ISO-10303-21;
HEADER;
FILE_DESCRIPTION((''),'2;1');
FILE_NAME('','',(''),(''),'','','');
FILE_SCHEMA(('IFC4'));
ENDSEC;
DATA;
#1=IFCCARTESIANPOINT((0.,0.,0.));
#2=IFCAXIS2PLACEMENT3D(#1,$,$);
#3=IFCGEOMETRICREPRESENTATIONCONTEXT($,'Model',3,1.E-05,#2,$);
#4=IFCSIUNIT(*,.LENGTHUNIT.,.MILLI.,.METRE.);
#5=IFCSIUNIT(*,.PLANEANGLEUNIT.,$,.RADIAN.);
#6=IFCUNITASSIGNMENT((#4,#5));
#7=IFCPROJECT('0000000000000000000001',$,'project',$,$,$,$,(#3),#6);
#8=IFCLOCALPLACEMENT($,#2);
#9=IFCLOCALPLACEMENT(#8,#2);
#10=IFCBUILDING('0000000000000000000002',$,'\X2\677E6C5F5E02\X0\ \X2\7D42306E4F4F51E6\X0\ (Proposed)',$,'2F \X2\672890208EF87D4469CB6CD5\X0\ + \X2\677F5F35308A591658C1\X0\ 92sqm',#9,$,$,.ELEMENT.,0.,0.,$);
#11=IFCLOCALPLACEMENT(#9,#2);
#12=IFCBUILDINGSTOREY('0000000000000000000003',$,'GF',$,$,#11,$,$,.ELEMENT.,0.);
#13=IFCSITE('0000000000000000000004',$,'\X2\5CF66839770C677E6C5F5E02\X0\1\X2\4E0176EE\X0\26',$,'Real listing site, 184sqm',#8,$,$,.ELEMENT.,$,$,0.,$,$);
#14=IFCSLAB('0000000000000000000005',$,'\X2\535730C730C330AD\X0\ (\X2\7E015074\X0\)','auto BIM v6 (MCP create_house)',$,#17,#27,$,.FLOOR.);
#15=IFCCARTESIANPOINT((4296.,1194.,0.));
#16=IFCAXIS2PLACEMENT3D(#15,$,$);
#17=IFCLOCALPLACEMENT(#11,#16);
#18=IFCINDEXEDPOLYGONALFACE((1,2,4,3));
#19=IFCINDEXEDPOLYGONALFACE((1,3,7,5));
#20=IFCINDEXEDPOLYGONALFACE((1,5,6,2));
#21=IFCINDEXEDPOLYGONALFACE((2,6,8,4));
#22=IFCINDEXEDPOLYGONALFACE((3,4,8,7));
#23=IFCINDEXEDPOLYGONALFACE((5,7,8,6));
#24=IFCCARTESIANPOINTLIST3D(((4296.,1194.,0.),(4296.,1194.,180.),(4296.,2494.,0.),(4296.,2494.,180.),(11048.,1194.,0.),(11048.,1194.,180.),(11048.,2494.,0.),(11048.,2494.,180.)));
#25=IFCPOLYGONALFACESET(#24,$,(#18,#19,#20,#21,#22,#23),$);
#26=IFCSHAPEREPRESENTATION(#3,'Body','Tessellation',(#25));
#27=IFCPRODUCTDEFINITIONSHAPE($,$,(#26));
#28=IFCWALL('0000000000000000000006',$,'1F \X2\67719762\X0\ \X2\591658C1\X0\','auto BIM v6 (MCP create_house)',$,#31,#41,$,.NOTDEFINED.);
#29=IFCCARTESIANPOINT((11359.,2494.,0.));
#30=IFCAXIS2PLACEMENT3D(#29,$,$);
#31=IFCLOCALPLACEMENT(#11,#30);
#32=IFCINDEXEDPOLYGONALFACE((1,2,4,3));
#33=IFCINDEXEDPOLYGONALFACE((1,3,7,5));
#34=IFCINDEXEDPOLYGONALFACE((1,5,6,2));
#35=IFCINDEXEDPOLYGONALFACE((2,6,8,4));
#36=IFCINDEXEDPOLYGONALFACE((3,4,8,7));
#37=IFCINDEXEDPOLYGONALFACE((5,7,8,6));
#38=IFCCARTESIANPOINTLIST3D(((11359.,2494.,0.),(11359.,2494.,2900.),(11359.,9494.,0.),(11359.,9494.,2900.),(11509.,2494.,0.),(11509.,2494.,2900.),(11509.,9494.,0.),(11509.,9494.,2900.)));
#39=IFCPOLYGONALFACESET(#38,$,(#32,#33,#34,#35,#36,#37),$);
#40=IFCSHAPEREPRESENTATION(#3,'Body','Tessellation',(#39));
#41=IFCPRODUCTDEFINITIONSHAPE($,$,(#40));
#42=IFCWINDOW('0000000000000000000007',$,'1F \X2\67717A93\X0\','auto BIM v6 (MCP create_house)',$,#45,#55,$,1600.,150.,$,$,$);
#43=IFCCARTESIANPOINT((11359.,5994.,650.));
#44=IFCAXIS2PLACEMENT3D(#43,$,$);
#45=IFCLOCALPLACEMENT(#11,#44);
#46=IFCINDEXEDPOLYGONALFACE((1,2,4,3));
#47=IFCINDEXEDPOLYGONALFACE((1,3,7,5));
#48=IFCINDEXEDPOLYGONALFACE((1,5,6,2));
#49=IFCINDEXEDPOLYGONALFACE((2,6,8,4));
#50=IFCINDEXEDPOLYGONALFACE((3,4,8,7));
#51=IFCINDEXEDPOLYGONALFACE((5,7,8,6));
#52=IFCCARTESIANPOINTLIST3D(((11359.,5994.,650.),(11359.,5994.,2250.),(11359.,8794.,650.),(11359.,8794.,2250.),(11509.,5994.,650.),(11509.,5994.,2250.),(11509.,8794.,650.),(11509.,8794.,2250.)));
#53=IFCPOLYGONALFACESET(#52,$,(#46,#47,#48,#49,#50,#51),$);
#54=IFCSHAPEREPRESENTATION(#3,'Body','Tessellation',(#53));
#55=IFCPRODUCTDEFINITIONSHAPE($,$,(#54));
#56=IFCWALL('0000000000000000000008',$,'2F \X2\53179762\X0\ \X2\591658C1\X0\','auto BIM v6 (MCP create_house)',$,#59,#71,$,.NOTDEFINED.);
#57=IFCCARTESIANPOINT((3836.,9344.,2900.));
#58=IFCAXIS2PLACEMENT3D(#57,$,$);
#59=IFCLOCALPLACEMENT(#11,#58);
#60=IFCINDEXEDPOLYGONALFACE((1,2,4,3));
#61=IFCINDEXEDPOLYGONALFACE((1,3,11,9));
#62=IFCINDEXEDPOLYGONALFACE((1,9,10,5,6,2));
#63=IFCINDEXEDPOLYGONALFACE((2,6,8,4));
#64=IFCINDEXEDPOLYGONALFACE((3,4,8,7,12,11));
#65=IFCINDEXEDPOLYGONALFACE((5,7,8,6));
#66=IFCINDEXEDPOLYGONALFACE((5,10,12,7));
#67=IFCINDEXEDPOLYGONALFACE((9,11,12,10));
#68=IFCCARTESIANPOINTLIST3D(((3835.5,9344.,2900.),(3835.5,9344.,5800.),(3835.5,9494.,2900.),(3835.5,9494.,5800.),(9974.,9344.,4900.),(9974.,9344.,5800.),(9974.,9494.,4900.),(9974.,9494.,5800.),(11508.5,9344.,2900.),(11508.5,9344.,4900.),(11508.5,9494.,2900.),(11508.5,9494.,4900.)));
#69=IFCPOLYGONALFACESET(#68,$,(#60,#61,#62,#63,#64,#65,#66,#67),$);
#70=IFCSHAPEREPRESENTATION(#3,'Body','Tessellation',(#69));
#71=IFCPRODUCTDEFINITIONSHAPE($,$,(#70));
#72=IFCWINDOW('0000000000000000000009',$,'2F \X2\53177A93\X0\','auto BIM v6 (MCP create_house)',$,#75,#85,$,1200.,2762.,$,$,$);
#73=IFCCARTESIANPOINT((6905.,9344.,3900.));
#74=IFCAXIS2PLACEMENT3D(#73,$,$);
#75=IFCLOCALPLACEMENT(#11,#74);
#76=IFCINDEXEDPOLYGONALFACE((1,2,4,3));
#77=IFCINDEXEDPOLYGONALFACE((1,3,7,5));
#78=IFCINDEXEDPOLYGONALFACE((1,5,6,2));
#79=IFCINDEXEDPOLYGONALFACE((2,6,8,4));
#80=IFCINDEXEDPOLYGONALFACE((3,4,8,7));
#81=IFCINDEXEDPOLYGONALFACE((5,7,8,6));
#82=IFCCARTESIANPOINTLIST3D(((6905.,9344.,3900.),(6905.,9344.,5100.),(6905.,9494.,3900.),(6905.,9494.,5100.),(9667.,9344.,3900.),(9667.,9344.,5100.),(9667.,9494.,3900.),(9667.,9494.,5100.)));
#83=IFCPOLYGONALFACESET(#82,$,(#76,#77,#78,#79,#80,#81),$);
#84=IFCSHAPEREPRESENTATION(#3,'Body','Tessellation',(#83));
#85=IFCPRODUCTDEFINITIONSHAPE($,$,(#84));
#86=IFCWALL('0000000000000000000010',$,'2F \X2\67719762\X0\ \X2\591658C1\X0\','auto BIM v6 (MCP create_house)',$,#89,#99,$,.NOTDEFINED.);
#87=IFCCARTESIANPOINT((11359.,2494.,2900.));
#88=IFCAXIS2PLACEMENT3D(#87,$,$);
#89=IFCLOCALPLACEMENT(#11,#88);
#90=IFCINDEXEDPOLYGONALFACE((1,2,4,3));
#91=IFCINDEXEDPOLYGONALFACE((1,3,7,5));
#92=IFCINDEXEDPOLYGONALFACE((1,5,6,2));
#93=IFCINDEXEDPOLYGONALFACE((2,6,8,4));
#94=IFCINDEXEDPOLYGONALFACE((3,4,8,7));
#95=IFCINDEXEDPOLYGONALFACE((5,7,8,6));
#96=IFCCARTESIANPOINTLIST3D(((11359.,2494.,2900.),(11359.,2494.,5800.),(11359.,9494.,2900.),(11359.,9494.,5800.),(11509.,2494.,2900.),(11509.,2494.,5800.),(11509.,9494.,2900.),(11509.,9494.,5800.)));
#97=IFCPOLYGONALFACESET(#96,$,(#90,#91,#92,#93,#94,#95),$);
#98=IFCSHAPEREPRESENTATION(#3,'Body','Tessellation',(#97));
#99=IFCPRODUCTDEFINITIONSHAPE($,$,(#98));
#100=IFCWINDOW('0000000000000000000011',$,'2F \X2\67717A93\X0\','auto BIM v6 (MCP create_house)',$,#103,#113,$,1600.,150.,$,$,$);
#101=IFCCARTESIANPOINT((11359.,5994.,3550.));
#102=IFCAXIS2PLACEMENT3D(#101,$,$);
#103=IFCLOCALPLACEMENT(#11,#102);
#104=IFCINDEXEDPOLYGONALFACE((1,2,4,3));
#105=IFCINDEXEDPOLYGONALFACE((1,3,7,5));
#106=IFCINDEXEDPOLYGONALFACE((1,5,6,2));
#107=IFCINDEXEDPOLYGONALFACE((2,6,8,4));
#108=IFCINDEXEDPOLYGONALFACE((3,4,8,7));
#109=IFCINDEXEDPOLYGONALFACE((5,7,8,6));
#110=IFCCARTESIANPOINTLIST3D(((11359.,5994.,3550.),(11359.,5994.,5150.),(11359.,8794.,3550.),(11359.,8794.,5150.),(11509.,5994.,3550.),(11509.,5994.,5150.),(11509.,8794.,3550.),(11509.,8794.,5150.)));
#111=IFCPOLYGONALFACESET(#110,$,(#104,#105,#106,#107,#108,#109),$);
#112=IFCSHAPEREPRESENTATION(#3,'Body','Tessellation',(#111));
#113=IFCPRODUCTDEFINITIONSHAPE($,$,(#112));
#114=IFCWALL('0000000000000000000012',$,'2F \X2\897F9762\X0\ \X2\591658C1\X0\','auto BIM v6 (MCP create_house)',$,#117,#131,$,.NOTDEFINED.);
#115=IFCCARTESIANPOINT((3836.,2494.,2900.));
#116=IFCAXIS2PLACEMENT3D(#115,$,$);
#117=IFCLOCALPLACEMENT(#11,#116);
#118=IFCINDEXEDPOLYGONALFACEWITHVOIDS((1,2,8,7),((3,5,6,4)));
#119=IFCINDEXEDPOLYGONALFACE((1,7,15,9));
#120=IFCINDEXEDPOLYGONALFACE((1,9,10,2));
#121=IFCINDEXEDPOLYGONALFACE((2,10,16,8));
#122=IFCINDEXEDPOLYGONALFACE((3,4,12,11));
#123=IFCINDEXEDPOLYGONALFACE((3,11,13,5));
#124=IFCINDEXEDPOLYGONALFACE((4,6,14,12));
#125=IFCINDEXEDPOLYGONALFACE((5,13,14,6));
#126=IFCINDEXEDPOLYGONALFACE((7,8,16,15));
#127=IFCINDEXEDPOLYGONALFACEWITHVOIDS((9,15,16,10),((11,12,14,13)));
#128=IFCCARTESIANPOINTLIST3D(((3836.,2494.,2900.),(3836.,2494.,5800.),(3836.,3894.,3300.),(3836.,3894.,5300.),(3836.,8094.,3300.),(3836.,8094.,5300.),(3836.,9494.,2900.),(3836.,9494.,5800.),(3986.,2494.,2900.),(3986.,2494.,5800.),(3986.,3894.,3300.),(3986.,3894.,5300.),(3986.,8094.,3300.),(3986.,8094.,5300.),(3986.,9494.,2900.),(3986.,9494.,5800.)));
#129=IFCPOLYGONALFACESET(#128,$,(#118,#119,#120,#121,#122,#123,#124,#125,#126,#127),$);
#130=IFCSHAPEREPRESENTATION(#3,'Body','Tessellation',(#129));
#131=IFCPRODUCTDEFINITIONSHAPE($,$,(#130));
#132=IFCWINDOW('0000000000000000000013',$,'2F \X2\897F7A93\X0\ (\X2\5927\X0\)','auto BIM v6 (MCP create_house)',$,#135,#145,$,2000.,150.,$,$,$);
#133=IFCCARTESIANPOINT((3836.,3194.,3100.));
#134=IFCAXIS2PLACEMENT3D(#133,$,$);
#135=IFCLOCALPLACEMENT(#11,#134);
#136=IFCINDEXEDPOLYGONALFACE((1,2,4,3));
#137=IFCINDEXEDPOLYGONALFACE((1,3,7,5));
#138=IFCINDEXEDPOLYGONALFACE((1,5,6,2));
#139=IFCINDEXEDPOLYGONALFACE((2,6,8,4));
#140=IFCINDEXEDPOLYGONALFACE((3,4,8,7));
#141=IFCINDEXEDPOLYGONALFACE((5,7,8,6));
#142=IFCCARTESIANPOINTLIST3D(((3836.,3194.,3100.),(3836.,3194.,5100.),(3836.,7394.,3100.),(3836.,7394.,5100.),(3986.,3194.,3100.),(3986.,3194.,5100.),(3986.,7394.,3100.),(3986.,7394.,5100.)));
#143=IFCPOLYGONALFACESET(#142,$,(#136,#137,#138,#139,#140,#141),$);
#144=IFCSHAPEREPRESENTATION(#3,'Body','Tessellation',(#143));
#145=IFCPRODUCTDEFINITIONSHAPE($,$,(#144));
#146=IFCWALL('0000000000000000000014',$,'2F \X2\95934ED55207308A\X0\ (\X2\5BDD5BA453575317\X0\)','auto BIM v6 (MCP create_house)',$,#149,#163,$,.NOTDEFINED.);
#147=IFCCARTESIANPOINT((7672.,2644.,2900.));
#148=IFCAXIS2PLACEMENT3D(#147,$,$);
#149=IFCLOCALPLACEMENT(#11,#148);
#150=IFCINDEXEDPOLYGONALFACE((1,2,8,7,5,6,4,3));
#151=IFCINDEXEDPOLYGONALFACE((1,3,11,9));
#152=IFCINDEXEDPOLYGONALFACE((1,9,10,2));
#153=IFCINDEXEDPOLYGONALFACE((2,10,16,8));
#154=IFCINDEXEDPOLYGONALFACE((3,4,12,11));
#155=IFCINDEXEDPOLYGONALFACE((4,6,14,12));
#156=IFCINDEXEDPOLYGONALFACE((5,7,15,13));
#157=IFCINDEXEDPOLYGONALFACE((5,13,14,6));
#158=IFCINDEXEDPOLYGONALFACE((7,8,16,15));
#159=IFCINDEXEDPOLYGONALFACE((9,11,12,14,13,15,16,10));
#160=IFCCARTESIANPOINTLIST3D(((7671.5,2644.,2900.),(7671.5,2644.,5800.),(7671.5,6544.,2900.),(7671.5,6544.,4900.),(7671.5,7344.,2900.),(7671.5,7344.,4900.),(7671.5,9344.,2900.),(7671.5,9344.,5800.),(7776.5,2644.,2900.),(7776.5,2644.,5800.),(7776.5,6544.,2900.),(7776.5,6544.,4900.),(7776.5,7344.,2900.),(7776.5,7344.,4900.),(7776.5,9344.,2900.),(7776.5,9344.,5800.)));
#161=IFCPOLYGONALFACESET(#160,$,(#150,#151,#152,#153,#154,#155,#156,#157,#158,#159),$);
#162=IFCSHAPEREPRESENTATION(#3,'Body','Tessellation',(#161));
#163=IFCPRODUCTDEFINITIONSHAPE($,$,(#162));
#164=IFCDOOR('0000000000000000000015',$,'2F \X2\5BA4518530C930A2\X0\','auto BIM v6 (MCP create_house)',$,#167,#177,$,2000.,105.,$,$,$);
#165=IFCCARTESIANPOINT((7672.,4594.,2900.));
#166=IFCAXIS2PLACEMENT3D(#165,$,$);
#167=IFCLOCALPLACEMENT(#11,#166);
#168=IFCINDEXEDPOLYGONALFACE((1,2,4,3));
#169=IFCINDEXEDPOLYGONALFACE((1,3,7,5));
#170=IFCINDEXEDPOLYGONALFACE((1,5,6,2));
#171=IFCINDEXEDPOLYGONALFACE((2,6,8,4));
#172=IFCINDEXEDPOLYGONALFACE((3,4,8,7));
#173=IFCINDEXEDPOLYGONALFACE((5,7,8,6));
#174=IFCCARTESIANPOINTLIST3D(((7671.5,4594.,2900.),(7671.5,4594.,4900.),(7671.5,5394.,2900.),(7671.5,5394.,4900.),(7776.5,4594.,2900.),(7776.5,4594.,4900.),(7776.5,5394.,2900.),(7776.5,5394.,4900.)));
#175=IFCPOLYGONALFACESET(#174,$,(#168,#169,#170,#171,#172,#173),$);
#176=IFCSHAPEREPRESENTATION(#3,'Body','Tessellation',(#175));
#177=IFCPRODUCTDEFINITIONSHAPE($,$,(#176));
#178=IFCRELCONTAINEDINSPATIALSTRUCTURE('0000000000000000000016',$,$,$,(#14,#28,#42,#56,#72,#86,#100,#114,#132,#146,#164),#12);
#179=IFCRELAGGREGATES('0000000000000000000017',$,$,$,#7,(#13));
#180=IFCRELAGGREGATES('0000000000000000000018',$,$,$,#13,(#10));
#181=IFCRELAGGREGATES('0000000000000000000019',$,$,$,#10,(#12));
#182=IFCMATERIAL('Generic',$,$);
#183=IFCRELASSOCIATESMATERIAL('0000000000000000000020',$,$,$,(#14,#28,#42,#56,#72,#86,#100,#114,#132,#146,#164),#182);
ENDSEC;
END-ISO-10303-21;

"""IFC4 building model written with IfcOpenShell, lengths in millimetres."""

from ifc_helpers import new_model, si_unit, frame, frame_2d, origin, place, context, project, spatial, rectangle, extrude, material, element, fill, save


model = new_model("IFC4")

# Units and contexts
model_context = context("Model", 3, precision=1e-05, world=origin())
ifc_project = project(units=[si_unit("LENGTHUNIT", "METRE", prefix="MILLI"), si_unit("PLANEANGLEUNIT", "RADIAN")], contexts=[model_context])

# Site, building, storey
site_placement = place(None, origin())
site = spatial("IfcSite", under=ifc_project, at=site_placement, Name="島根県松江市1丁目26", ObjectType="Real listing site, 184sqm", CompositionType="ELEMENT", RefElevation=0.0)
building_placement = place(site_placement, origin())
building = spatial("IfcBuilding", under=site, at=building_placement, Name="松江市 終の住処 (Proposed)", ObjectType="2F 木造軸組構法 + 板張り外壁 92sqm", CompositionType="ELEMENT", ElevationOfRefHeight=0.0, ElevationOfTerrain=0.0)
storey_placement = place(building_placement, origin())
storey = spatial("IfcBuildingStorey", under=building, at=storey_placement, Name="GF", CompositionType="ELEMENT", Elevation=0.0)

# Slab
ifc_material = material(Name="Generic")
slab_placement = place(storey_placement, frame((4296.0, 1194.0, 0.0)))
element("IfcSlab", 1, at=slab_placement, inside=storey, material=ifc_material, Name="南デッキ (縁側)", Description="auto BIM v6 (MCP create_house)", PredefinedType="FLOOR", context=model_context, shape_type="SweptSolid", body=[
    extrude(rectangle(XDim=6752.0, YDim=1300.0, at=frame_2d((3376.0, 650.0))), frame((4296.0, 1194.0, 0.0)), (0.0, 0.0, 1.0), 180.0),
])

# Wall, opening, window
wall_1_placement = place(storey_placement, frame((11359.0, 2494.0, 0.0)))
wall_1 = element("IfcWall", 2, at=wall_1_placement, inside=storey, material=ifc_material, Name="1F 東面 外壁", Description="auto BIM v6 (MCP create_house)", PredefinedType="NOTDEFINED", context=model_context, shape_type="SweptSolid", body=[
    extrude(rectangle(XDim=150.0, YDim=7000.0, at=frame_2d((75.0, 3500.0))), frame((11359.0, 2494.0, 0.0)), (0.0, 0.0, 1.0), 2900.0),
])
opening_1_placement = place(storey_placement, frame((11359.0, 5994.0, 650.0)))
opening_1 = element("IfcOpeningElement", 3, at=opening_1_placement, cuts=wall_1, PredefinedType="NOTDEFINED", context=model_context, shape_type="SweptSolid", body=[
    extrude(rectangle(XDim=150.0, YDim=2800.0, at=frame_2d((75.0, 1400.0))), frame((11359.0, 5994.0, 650.0)), (0.0, 0.0, 1.0), 1600.0),
])
window_1_placement = place(storey_placement, frame((11359.0, 5994.0, 650.0)))
window_1 = element("IfcWindow", 4, at=window_1_placement, inside=storey, material=ifc_material, Name="1F 東窓", Description="auto BIM v6 (MCP create_house)", OverallHeight=1600.0, OverallWidth=150.0, context=model_context, shape_type="SweptSolid", body=[
    extrude(rectangle(XDim=150.0, YDim=2800.0, at=frame_2d((75.0, 1400.0))), frame((11359.0, 5994.0, 650.0)), (0.0, 0.0, 1.0), 1600.0),
])
fill(opening_1, window_1)

# Walls, openings, windows
wall_2_placement = place(storey_placement, frame((3836.0, 9344.0, 2900.0)))
wall_2 = element("IfcWall", 5, at=wall_2_placement, inside=storey, material=ifc_material, Name="2F 北面 外壁", Description="auto BIM v6 (MCP create_house)", PredefinedType="NOTDEFINED", context=model_context, shape_type="SweptSolid", body=[
    extrude(rectangle(XDim=7673.0, YDim=150.0, at=frame_2d((3836.0, 75.0))), frame((3836.0, 9344.0, 2900.0)), (0.0, 0.0, 1.0), 2900.0),
])
opening_2_placement = place(storey_placement, frame((6905.0, 9344.0, 3900.0)))
opening_2 = element("IfcOpeningElement", 6, at=opening_2_placement, cuts=wall_2, PredefinedType="NOTDEFINED", context=model_context, shape_type="SweptSolid", body=[
    extrude(rectangle(XDim=2762.0, YDim=150.0, at=frame_2d((1381.0, 75.0))), frame((6905.0, 9344.0, 3900.0)), (0.0, 0.0, 1.0), 1200.0),
])
window_2_placement = place(storey_placement, frame((6905.0, 9344.0, 3900.0)))
window_2 = element("IfcWindow", 7, at=window_2_placement, inside=storey, material=ifc_material, Name="2F 北窓", Description="auto BIM v6 (MCP create_house)", OverallHeight=1200.0, OverallWidth=2762.0, context=model_context, shape_type="SweptSolid", body=[
    extrude(rectangle(XDim=2762.0, YDim=150.0, at=frame_2d((1381.0, 75.0))), frame((6905.0, 9344.0, 3900.0)), (0.0, 0.0, 1.0), 1200.0),
])
fill(opening_2, window_2)
wall_3_placement = place(storey_placement, frame((11359.0, 2494.0, 2900.0)))
wall_3 = element("IfcWall", 8, at=wall_3_placement, inside=storey, material=ifc_material, Name="2F 東面 外壁", Description="auto BIM v6 (MCP create_house)", PredefinedType="NOTDEFINED", context=model_context, shape_type="SweptSolid", body=[
    extrude(rectangle(XDim=150.0, YDim=7000.0, at=frame_2d((75.0, 3500.0))), frame((11359.0, 2494.0, 2900.0)), (0.0, 0.0, 1.0), 2900.0),
])
opening_3_placement = place(storey_placement, frame((11359.0, 5994.0, 3550.0)))
opening_3 = element("IfcOpeningElement", 9, at=opening_3_placement, cuts=wall_3, PredefinedType="NOTDEFINED", context=model_context, shape_type="SweptSolid", body=[
    extrude(rectangle(XDim=150.0, YDim=2800.0, at=frame_2d((75.0, 1400.0))), frame((11359.0, 5994.0, 3550.0)), (0.0, 0.0, 1.0), 1600.0),
])
window_3_placement = place(storey_placement, frame((11359.0, 5994.0, 3550.0)))
window_3 = element("IfcWindow", 10, at=window_3_placement, inside=storey, material=ifc_material, Name="2F 東窓", Description="auto BIM v6 (MCP create_house)", OverallHeight=1600.0, OverallWidth=150.0, context=model_context, shape_type="SweptSolid", body=[
    extrude(rectangle(XDim=150.0, YDim=2800.0, at=frame_2d((75.0, 1400.0))), frame((11359.0, 5994.0, 3550.0)), (0.0, 0.0, 1.0), 1600.0),
])
fill(opening_3, window_3)
wall_4_placement = place(storey_placement, frame((3836.0, 2494.0, 2900.0)))
wall_4 = element("IfcWall", 11, at=wall_4_placement, inside=storey, material=ifc_material, Name="2F 西面 外壁", Description="auto BIM v6 (MCP create_house)", PredefinedType="NOTDEFINED", context=model_context, shape_type="SweptSolid", body=[
    extrude(rectangle(XDim=150.0, YDim=7000.0, at=frame_2d((75.0, 3500.0))), frame((3836.0, 2494.0, 2900.0)), (0.0, 0.0, 1.0), 2900.0),
])
opening_4_placement = place(storey_placement, frame((3836.0, 3194.0, 3100.0)))
opening_4 = element("IfcOpeningElement", 12, at=opening_4_placement, cuts=wall_4, PredefinedType="NOTDEFINED", context=model_context, shape_type="SweptSolid", body=[
    extrude(rectangle(XDim=150.0, YDim=4200.0, at=frame_2d((75.0, 2100.0))), frame((3836.0, 3194.0, 3100.0)), (0.0, 0.0, 1.0), 2000.0),
])
window_4_placement = place(storey_placement, frame((3836.0, 3194.0, 3100.0)))
window_4 = element("IfcWindow", 13, at=window_4_placement, inside=storey, material=ifc_material, Name="2F 西窓 (大)", Description="auto BIM v6 (MCP create_house)", OverallHeight=2000.0, OverallWidth=150.0, context=model_context, shape_type="SweptSolid", body=[
    extrude(rectangle(XDim=150.0, YDim=4200.0, at=frame_2d((75.0, 2100.0))), frame((3836.0, 3194.0, 3100.0)), (0.0, 0.0, 1.0), 2000.0),
])
fill(opening_4, window_4)

# Wall, opening, door
wall_5_placement = place(storey_placement, frame((7672.0, 2644.0, 2900.0)))
wall_5 = element("IfcWall", 14, at=wall_5_placement, inside=storey, material=ifc_material, Name="2F 間仕切り (寝室南北)", Description="auto BIM v6 (MCP create_house)", PredefinedType="NOTDEFINED", context=model_context, shape_type="SweptSolid", body=[
    extrude(rectangle(XDim=105.0, YDim=6700.0, at=frame_2d((52.0, 3350.0))), frame((7672.0, 2644.0, 2900.0)), (0.0, 0.0, 1.0), 2900.0),
])
opening_5_placement = place(storey_placement, frame((7672.0, 4594.0, 2900.0)))
opening_5 = element("IfcOpeningElement", 15, at=opening_5_placement, cuts=wall_5, PredefinedType="NOTDEFINED", context=model_context, shape_type="SweptSolid", body=[
    extrude(rectangle(XDim=105.0, YDim=800.0, at=frame_2d((52.0, 400.0))), frame((7672.0, 4594.0, 2900.0)), (0.0, 0.0, 1.0), 2000.0),
])
door_placement = place(storey_placement, frame((7672.0, 4594.0, 2900.0)))
door = element("IfcDoor", 16, at=door_placement, inside=storey, material=ifc_material, Name="2F 室内ドア", Description="auto BIM v6 (MCP create_house)", OverallHeight=2000.0, OverallWidth=105.0, context=model_context, shape_type="SweptSolid", body=[
    extrude(rectangle(XDim=105.0, YDim=800.0, at=frame_2d((52.0, 400.0))), frame((7672.0, 4594.0, 2900.0)), (0.0, 0.0, 1.0), 2000.0),
])
fill(opening_5, door)

save(model, "model.ifc")
